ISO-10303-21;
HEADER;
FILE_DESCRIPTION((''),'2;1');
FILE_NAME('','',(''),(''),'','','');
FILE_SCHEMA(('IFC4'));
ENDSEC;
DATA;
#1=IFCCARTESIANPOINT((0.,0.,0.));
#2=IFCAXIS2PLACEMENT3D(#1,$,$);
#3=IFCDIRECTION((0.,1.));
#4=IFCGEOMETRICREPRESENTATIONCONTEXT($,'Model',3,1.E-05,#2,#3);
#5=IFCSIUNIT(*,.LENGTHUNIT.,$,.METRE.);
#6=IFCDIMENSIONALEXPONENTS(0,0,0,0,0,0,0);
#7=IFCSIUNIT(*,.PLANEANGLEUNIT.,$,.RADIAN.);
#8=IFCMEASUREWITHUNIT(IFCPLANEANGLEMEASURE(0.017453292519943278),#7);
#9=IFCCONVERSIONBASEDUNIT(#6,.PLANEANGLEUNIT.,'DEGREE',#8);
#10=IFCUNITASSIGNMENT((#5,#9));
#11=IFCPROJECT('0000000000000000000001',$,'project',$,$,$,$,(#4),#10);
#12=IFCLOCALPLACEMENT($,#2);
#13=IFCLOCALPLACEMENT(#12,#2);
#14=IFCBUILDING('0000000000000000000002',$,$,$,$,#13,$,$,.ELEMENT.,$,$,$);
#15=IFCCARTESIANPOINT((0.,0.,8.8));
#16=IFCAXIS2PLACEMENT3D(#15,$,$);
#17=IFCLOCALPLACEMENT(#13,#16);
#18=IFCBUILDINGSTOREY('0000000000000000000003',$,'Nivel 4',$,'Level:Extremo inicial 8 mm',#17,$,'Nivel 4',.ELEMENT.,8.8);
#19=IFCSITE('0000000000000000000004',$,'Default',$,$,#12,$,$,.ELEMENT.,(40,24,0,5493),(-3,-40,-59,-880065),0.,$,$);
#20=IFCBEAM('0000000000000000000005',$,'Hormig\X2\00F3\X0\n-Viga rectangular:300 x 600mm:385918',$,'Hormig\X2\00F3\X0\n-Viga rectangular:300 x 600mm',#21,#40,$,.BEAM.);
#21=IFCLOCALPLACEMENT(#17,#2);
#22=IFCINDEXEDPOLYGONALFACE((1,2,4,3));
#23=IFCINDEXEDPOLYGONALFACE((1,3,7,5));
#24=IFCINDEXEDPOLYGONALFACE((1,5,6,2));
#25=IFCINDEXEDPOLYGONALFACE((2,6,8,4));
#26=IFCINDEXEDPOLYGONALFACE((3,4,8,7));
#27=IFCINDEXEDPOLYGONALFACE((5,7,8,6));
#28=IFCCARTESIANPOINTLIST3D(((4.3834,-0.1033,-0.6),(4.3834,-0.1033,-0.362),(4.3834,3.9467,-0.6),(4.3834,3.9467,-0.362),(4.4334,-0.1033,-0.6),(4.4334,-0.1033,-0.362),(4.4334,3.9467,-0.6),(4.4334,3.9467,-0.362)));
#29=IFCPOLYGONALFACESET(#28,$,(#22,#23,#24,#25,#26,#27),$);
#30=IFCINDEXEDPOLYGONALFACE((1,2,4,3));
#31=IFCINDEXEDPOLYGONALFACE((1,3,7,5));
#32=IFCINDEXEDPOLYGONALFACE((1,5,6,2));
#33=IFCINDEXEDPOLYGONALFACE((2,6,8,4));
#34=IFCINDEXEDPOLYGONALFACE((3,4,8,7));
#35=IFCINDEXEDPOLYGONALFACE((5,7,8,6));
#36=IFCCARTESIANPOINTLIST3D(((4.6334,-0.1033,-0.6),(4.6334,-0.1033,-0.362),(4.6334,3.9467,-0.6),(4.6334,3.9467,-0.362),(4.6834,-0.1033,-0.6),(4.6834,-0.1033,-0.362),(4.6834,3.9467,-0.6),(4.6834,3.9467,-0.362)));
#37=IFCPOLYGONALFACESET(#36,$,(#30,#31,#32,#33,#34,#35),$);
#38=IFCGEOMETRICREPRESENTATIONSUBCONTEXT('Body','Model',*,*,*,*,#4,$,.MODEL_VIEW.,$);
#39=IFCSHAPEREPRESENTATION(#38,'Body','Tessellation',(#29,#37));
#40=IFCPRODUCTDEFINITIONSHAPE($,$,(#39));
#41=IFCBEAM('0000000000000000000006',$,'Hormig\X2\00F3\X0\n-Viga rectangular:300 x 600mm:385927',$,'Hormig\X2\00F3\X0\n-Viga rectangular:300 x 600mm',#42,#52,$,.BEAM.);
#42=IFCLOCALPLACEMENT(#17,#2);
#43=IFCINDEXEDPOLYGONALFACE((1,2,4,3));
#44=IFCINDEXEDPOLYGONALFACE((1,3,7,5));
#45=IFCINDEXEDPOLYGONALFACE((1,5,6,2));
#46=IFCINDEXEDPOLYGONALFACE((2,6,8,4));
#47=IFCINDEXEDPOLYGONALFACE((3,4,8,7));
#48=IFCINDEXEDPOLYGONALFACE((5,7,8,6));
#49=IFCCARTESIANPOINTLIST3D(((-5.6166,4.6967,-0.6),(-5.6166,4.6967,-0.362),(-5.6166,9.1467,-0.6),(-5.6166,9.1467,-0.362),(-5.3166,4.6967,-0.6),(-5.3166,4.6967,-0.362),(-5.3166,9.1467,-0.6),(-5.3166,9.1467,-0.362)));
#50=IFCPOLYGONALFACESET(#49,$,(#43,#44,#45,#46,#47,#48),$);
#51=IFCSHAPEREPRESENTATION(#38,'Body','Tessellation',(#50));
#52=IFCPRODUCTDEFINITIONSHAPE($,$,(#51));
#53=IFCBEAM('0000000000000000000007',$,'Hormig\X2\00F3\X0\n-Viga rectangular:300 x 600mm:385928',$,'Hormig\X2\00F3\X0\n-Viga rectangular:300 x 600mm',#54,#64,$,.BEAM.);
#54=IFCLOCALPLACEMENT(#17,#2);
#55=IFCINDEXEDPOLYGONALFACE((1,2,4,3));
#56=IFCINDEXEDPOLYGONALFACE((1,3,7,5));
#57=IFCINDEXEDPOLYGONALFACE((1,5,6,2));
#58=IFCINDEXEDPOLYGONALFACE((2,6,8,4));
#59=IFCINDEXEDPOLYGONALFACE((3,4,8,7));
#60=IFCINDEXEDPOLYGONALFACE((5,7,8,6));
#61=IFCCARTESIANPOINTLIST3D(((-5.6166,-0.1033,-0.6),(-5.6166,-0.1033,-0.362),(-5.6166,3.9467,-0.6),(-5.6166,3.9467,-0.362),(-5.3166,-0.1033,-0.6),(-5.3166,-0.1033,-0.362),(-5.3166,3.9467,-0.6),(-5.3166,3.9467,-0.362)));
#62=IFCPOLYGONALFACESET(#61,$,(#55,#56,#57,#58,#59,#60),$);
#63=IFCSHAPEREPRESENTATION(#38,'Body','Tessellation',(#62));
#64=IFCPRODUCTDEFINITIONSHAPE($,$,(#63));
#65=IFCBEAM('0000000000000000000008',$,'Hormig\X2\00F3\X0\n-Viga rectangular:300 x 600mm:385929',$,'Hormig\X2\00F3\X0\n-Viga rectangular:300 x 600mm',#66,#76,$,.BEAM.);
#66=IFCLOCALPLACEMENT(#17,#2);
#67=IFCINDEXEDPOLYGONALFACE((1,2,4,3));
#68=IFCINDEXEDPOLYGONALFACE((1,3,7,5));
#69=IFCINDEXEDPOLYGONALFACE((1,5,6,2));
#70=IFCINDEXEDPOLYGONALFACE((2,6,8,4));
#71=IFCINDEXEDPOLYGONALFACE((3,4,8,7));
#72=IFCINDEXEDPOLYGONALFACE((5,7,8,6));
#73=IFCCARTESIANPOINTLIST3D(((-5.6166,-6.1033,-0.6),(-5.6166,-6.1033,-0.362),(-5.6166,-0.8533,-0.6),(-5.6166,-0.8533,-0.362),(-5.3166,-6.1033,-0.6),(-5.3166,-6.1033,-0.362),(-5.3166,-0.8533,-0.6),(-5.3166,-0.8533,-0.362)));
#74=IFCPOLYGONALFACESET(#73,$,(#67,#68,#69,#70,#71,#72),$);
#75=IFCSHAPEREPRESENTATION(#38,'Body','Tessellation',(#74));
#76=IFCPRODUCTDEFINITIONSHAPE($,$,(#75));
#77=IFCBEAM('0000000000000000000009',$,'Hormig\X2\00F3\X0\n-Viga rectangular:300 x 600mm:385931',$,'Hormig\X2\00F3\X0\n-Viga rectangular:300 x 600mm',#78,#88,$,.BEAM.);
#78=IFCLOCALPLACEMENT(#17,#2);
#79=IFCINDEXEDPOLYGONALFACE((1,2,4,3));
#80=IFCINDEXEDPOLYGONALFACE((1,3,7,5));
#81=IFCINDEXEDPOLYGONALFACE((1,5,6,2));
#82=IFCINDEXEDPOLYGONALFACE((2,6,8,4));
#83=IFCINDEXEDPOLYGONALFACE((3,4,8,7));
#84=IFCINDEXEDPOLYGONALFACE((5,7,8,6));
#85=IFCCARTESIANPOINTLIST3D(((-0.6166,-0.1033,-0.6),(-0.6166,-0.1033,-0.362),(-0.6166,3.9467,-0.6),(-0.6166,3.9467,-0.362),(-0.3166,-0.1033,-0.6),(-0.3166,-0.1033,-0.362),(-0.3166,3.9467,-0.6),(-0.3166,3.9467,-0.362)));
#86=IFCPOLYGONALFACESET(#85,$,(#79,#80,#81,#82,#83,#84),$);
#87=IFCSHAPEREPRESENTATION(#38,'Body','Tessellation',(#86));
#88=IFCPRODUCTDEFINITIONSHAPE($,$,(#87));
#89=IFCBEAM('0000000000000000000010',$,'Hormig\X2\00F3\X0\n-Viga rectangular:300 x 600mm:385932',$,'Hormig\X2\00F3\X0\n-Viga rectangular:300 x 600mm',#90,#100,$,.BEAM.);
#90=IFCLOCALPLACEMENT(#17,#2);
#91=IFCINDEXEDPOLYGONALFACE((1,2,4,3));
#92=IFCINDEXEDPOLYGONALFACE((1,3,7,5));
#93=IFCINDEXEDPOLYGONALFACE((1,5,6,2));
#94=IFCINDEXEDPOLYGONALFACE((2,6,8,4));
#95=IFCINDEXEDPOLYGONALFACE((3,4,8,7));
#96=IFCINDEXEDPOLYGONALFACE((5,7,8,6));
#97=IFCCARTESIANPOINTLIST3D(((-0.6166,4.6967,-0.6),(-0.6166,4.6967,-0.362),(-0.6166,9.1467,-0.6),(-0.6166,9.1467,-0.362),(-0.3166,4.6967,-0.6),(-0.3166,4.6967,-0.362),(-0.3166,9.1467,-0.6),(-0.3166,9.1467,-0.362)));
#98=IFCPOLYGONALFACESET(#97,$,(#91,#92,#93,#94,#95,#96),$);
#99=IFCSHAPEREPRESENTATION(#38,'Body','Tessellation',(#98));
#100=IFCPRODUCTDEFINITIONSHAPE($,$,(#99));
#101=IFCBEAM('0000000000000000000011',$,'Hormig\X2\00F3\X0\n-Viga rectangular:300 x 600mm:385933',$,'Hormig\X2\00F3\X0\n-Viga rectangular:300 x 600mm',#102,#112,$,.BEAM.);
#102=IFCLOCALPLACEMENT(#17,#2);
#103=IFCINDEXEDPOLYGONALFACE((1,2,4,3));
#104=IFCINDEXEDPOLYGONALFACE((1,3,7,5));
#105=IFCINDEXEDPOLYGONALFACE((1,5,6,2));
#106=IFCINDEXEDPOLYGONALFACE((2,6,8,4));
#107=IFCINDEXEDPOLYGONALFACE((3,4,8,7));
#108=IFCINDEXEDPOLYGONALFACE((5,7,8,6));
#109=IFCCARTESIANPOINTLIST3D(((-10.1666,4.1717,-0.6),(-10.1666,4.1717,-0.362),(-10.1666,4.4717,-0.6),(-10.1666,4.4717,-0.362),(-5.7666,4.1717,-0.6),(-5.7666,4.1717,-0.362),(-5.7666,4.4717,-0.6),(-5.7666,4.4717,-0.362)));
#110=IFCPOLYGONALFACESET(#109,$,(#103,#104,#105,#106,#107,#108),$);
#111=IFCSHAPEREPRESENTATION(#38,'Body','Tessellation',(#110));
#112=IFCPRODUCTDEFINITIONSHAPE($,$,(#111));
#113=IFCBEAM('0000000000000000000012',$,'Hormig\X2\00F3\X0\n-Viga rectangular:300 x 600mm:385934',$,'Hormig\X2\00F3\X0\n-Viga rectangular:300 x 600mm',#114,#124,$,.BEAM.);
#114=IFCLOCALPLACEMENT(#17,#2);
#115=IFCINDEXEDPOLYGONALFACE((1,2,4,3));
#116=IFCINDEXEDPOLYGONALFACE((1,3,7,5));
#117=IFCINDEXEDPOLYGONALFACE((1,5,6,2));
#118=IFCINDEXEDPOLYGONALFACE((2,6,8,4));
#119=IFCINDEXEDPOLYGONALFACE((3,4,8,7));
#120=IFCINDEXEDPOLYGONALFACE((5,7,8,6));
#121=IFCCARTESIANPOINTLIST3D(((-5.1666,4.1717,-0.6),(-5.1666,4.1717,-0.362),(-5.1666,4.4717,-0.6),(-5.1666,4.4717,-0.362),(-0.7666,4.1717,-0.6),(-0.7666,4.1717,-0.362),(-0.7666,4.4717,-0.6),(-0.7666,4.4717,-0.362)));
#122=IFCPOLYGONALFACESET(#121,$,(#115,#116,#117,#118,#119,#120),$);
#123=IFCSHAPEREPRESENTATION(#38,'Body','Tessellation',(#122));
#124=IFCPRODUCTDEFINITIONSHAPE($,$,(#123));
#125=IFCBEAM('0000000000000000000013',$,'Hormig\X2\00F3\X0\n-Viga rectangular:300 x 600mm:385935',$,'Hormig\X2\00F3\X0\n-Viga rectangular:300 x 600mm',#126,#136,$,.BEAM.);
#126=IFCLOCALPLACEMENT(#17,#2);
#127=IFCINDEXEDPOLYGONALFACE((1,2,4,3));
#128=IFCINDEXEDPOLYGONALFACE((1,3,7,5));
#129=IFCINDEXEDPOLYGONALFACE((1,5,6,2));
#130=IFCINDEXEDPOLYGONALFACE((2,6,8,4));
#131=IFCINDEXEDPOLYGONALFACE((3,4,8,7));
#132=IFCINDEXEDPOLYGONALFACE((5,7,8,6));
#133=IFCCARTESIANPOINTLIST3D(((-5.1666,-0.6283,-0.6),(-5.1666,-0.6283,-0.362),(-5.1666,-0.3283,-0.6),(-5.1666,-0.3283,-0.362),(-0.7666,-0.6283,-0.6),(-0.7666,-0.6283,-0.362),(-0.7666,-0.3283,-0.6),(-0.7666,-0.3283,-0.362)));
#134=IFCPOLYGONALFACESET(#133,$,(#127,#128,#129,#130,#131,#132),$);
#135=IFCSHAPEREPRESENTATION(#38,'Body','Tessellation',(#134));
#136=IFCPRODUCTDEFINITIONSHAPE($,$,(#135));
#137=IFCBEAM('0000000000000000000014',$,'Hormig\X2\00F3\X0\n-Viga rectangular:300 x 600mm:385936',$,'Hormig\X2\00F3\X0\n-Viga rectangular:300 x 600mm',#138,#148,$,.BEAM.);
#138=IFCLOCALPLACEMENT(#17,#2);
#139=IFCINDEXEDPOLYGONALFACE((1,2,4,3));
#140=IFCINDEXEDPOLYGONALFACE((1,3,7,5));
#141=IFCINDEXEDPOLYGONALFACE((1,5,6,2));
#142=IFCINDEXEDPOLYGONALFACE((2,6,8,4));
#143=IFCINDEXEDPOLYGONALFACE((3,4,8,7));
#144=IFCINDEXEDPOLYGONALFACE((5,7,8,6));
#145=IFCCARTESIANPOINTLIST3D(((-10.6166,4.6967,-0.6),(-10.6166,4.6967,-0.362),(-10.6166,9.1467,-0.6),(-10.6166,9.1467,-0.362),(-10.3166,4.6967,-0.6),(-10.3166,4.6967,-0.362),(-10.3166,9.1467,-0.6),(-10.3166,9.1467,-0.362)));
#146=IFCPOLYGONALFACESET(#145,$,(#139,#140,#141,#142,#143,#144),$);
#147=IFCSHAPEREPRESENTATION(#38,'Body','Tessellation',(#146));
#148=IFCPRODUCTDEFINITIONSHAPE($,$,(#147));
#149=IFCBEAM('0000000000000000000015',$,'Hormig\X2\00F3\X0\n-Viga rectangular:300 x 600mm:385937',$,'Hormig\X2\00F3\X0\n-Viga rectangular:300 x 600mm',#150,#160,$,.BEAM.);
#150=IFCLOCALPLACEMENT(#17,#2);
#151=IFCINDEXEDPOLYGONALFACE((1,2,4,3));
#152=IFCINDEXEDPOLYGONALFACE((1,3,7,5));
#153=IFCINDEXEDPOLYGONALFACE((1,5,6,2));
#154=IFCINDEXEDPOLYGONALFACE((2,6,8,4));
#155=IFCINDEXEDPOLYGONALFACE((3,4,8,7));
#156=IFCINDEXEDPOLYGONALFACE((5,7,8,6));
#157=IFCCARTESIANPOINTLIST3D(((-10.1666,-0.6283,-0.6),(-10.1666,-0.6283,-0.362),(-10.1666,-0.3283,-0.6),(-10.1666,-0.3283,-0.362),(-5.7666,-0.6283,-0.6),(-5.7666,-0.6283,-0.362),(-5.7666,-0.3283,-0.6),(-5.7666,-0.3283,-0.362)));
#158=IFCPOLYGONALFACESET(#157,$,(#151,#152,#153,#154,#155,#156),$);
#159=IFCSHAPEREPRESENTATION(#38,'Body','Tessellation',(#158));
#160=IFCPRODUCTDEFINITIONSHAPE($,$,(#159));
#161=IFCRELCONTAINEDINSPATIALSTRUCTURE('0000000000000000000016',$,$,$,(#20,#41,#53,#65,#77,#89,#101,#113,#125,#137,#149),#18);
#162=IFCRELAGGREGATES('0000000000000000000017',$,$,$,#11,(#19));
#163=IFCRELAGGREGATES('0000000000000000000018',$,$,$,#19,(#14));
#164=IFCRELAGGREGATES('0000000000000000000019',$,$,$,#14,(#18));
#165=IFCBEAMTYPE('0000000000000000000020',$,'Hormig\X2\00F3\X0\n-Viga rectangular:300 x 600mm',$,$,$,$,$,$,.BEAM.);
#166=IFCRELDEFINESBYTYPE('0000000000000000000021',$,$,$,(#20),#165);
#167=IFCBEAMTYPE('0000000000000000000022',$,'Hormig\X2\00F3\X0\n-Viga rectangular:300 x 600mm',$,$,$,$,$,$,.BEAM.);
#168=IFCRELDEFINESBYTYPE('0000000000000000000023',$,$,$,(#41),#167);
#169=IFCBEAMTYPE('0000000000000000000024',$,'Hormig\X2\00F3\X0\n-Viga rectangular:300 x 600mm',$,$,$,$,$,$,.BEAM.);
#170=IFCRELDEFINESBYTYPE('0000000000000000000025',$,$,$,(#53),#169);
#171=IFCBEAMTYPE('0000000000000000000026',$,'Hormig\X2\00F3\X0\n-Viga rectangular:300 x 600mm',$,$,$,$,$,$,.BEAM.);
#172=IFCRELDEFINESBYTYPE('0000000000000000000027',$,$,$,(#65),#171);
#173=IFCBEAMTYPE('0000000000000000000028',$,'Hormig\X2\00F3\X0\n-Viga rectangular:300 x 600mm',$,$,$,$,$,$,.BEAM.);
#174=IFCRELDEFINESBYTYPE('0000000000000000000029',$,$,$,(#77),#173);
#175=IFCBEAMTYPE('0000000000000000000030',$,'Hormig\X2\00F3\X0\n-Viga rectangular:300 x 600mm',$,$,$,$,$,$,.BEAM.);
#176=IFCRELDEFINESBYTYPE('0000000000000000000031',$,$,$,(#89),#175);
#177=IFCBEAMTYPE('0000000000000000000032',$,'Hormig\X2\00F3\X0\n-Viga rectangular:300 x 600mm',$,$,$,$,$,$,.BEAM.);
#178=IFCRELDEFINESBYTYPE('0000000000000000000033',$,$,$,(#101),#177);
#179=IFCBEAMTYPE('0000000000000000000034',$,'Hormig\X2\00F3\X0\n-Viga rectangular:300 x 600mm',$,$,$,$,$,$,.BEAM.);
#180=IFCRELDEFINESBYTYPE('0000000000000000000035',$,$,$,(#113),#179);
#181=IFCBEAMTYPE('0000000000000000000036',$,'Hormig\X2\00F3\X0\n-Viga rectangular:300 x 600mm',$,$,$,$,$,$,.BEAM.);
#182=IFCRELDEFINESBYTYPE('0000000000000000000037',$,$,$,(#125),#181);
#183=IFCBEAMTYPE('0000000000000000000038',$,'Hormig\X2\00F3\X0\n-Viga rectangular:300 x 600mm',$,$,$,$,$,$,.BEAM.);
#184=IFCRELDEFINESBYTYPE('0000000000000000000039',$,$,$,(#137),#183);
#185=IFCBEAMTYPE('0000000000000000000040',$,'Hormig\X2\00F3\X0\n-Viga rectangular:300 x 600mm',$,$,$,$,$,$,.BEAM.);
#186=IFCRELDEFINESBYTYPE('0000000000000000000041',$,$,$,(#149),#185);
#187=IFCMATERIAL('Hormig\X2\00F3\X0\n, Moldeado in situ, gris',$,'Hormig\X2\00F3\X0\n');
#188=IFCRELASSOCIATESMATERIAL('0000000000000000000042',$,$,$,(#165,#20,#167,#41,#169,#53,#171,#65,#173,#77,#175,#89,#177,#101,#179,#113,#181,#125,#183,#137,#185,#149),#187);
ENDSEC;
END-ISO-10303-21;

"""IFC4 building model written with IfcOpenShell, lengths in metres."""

from ifc_helpers import new_model, entity, si_unit, converted_unit, direction, frame, origin, place, context, subcontext, project, spatial, indexed_curve, outline, extrude, source, transform, mapped, material, type_object, type_shapes, element, save


model = new_model("IFC4")

# Units and contexts
model_context = context("Model", 3, precision=1e-05, world=origin(), true_north=direction((0.0, 1.0)))
body_context = subcontext(model_context, "Body", "Model", "MODEL_VIEW")
ifc_project = project(units=[si_unit("LENGTHUNIT", "METRE"), converted_unit("PLANEANGLEUNIT", "DEGREE", entity("IfcPlaneAngleMeasure", 0.017453292519943278), si_unit("PLANEANGLEUNIT", "RADIAN"), dimensions=[0, 0, 0, 0, 0, 0, 0])], contexts=[model_context])

# Site, building, storey
site_placement = place(None, origin())
site = spatial("IfcSite", under=ifc_project, at=site_placement, Name="Default", CompositionType="ELEMENT", RefLatitude=(40, 24, 0, 5493), RefLongitude=(-3, -40, -59, -880065), RefElevation=0.0)
building_placement = place(site_placement, origin())
building = spatial("IfcBuilding", under=site, at=building_placement, CompositionType="ELEMENT")
storey_placement = place(building_placement, frame((0.0, 0.0, 8.8)))
storey = spatial("IfcBuildingStorey", under=building, at=storey_placement, Name="Nivel 4", ObjectType="Level:Extremo inicial 8 mm", LongName="Nivel 4", CompositionType="ELEMENT", Elevation=8.8)

# Shared definitions
ifc_material_1 = material(Name="Hormigón, Moldeado in situ, gris", Category="Hormigón")

# Beams
beam_type_1 = type_object("IfcBeamType", Name="Hormigón-Viga rectangular:300 x 600mm", PredefinedType="BEAM", material=ifc_material_1)
shared_shape_1 = source(origin(), body_context, "Body", "SweptSolid", [
    extrude(outline(indexed_curve([(-0.025, -0.119), (0.025, -0.119), (0.025, 0.119), (-0.025, 0.119), (-0.025, -0.119)], self_intersect=False)), frame((4.4084, 3.9467, 8.319), z_axis=(0.0, -1.0, 0.0), x_axis=(-1.0, 0.0, 0.0)), (0.0, 0.0, 1.0), 4.05),
    extrude(outline(indexed_curve([(-0.025, -0.119), (0.025, -0.119), (0.025, 0.119), (-0.025, 0.119), (-0.025, -0.119)], self_intersect=False)), frame((4.6584, 3.9467, 8.319), z_axis=(0.0, -1.0, 0.0), x_axis=(-1.0, 0.0, 0.0)), (0.0, 0.0, 1.0), 4.05),
])
type_shapes(beam_type_1, [shared_shape_1])
beam_1_placement = place(storey_placement, frame((0.0, 0.0, -8.8)))
element("IfcBeam", 1, at=beam_1_placement, inside=storey, type_object=beam_type_1, material=ifc_material_1, Name="Hormigón-Viga rectangular:300 x 600mm:385918", ObjectType="Hormigón-Viga rectangular:300 x 600mm", PredefinedType="BEAM", context=body_context, shape_type="MappedRepresentation", body=[
    mapped(shared_shape_1, transform((0.0, 0.0, 0.0), scale=1.0)),
])
beam_type_2 = type_object("IfcBeamType", Name="Hormigón-Viga rectangular:300 x 600mm", PredefinedType="BEAM", material=ifc_material_1)
shared_shape_2 = source(origin(), body_context, "Body", "SweptSolid", [
    extrude(outline(indexed_curve([(-0.15, -0.119), (0.15, -0.119), (0.15, 0.119), (-0.15, 0.119), (-0.15, -0.119)], self_intersect=False)), frame((-5.4666, 9.1467, 8.319), z_axis=(0.0, -1.0, 0.0), x_axis=(-1.0, 0.0, 0.0)), (0.0, 0.0, 1.0), 4.45),
])
type_shapes(beam_type_2, [shared_shape_2])
beam_2_placement = place(storey_placement, frame((0.0, 0.0, -8.8)))
element("IfcBeam", 2, at=beam_2_placement, inside=storey, type_object=beam_type_2, material=ifc_material_1, Name="Hormigón-Viga rectangular:300 x 600mm:385927", ObjectType="Hormigón-Viga rectangular:300 x 600mm", PredefinedType="BEAM", context=body_context, shape_type="MappedRepresentation", body=[
    mapped(shared_shape_2, transform((0.0, 0.0, 0.0), scale=1.0)),
])
beam_type_3 = type_object("IfcBeamType", Name="Hormigón-Viga rectangular:300 x 600mm", PredefinedType="BEAM", material=ifc_material_1)
shared_shape_3 = source(origin(), body_context, "Body", "SweptSolid", [
    extrude(outline(indexed_curve([(-0.15, -0.119), (0.15, -0.119), (0.15, 0.119), (-0.15, 0.119), (-0.15, -0.119)], self_intersect=False)), frame((-5.4666, 3.9467, 8.319), z_axis=(0.0, -1.0, 0.0), x_axis=(-1.0, 0.0, 0.0)), (0.0, 0.0, 1.0), 4.05),
])
type_shapes(beam_type_3, [shared_shape_3])
beam_3_placement = place(storey_placement, frame((0.0, 0.0, -8.8)))
element("IfcBeam", 3, at=beam_3_placement, inside=storey, type_object=beam_type_3, material=ifc_material_1, Name="Hormigón-Viga rectangular:300 x 600mm:385928", ObjectType="Hormigón-Viga rectangular:300 x 600mm", PredefinedType="BEAM", context=body_context, shape_type="MappedRepresentation", body=[
    mapped(shared_shape_3, transform((0.0, 0.0, 0.0), scale=1.0)),
])
beam_type_4 = type_object("IfcBeamType", Name="Hormigón-Viga rectangular:300 x 600mm", PredefinedType="BEAM", material=ifc_material_1)
shared_shape_4 = source(origin(), body_context, "Body", "SweptSolid", [
    extrude(outline(indexed_curve([(-0.15, -0.119), (0.15, -0.119), (0.15, 0.119), (-0.15, 0.119), (-0.15, -0.119)], self_intersect=False)), frame((-5.4666, -6.1033, 8.319), z_axis=(0.0, 1.0, 0.0), x_axis=(-1.0, 0.0, 0.0)), (0.0, 0.0, 1.0), 5.25),
])
type_shapes(beam_type_4, [shared_shape_4])
beam_4_placement = place(storey_placement, frame((0.0, 0.0, -8.8)))
element("IfcBeam", 4, at=beam_4_placement, inside=storey, type_object=beam_type_4, material=ifc_material_1, Name="Hormigón-Viga rectangular:300 x 600mm:385929", ObjectType="Hormigón-Viga rectangular:300 x 600mm", PredefinedType="BEAM", context=body_context, shape_type="MappedRepresentation", body=[
    mapped(shared_shape_4, transform((0.0, 0.0, 0.0), scale=1.0)),
])
beam_type_5 = type_object("IfcBeamType", Name="Hormigón-Viga rectangular:300 x 600mm", PredefinedType="BEAM", material=ifc_material_1)
shared_shape_5 = source(origin(), body_context, "Body", "SweptSolid", [
    extrude(outline(indexed_curve([(-0.15, -0.119), (0.15, -0.119), (0.15, 0.119), (-0.15, 0.119), (-0.15, -0.119)], self_intersect=False)), frame((-0.4666, -0.1033, 8.319), z_axis=(0.0, 1.0, 0.0), x_axis=(-1.0, 0.0, 0.0)), (0.0, 0.0, 1.0), 4.05),
])
type_shapes(beam_type_5, [shared_shape_5])
beam_5_placement = place(storey_placement, frame((0.0, 0.0, -8.8)))
element("IfcBeam", 5, at=beam_5_placement, inside=storey, type_object=beam_type_5, material=ifc_material_1, Name="Hormigón-Viga rectangular:300 x 600mm:385931", ObjectType="Hormigón-Viga rectangular:300 x 600mm", PredefinedType="BEAM", context=body_context, shape_type="MappedRepresentation", body=[
    mapped(shared_shape_5, transform((0.0, 0.0, 0.0), scale=1.0)),
])
beam_type_6 = type_object("IfcBeamType", Name="Hormigón-Viga rectangular:300 x 600mm", PredefinedType="BEAM", material=ifc_material_1)
shared_shape_6 = source(origin(), body_context, "Body", "SweptSolid", [
    extrude(outline(indexed_curve([(-0.15, -0.119), (0.15, -0.119), (0.15, 0.119), (-0.15, 0.119), (-0.15, -0.119)], self_intersect=False)), frame((-0.4666, 9.1467, 8.319), z_axis=(0.0, -1.0, 0.0), x_axis=(-1.0, 0.0, 0.0)), (0.0, 0.0, 1.0), 4.45),
])
type_shapes(beam_type_6, [shared_shape_6])
beam_6_placement = place(storey_placement, frame((0.0, 0.0, -8.8)))
element("IfcBeam", 6, at=beam_6_placement, inside=storey, type_object=beam_type_6, material=ifc_material_1, Name="Hormigón-Viga rectangular:300 x 600mm:385932", ObjectType="Hormigón-Viga rectangular:300 x 600mm", PredefinedType="BEAM", context=body_context, shape_type="MappedRepresentation", body=[
    mapped(shared_shape_6, transform((0.0, 0.0, 0.0), scale=1.0)),
])
beam_type_7 = type_object("IfcBeamType", Name="Hormigón-Viga rectangular:300 x 600mm", PredefinedType="BEAM", material=ifc_material_1)
shared_shape_7 = source(origin(), body_context, "Body", "SweptSolid", [
    extrude(outline(indexed_curve([(-0.119, -0.15), (0.119, -0.15), (0.119, 0.15), (-0.119, 0.15), (-0.119, -0.15)], self_intersect=False)), frame((-10.1666, 4.3217, 8.319), z_axis=(1.0, 0.0, 0.0), x_axis=(0.0, 0.0, -1.0)), (0.0, 0.0, 1.0), 4.4),
])
type_shapes(beam_type_7, [shared_shape_7])
beam_7_placement = place(storey_placement, frame((0.0, 0.0, -8.8)))
element("IfcBeam", 7, at=beam_7_placement, inside=storey, type_object=beam_type_7, material=ifc_material_1, Name="Hormigón-Viga rectangular:300 x 600mm:385933", ObjectType="Hormigón-Viga rectangular:300 x 600mm", PredefinedType="BEAM", context=body_context, shape_type="MappedRepresentation", body=[
    mapped(shared_shape_7, transform((0.0, 0.0, 0.0), scale=1.0)),
])
beam_type_8 = type_object("IfcBeamType", Name="Hormigón-Viga rectangular:300 x 600mm", PredefinedType="BEAM", material=ifc_material_1)
shared_shape_8 = source(origin(), body_context, "Body", "SweptSolid", [
    extrude(outline(indexed_curve([(-0.119, -0.15), (0.119, -0.15), (0.119, 0.15), (-0.119, 0.15), (-0.119, -0.15)], self_intersect=False)), frame((-5.1666, 4.3217, 8.319), z_axis=(1.0, 0.0, 0.0), x_axis=(0.0, 0.0, -1.0)), (0.0, 0.0, 1.0), 4.4),
])
type_shapes(beam_type_8, [shared_shape_8])
beam_8_placement = place(storey_placement, frame((0.0, 0.0, -8.8)))
element("IfcBeam", 8, at=beam_8_placement, inside=storey, type_object=beam_type_8, material=ifc_material_1, Name="Hormigón-Viga rectangular:300 x 600mm:385934", ObjectType="Hormigón-Viga rectangular:300 x 600mm", PredefinedType="BEAM", context=body_context, shape_type="MappedRepresentation", body=[
    mapped(shared_shape_8, transform((0.0, 0.0, 0.0), scale=1.0)),
])
beam_type_9 = type_object("IfcBeamType", Name="Hormigón-Viga rectangular:300 x 600mm", PredefinedType="BEAM", material=ifc_material_1)
shared_shape_9 = source(origin(), body_context, "Body", "SweptSolid", [
    extrude(outline(indexed_curve([(-0.119, -0.15), (0.119, -0.15), (0.119, 0.15), (-0.119, 0.15), (-0.119, -0.15)], self_intersect=False)), frame((-0.7666, -0.4783, 8.319), z_axis=(-1.0, 0.0, 0.0), x_axis=(0.0, 0.0, -1.0)), (0.0, 0.0, 1.0), 4.4),
])
type_shapes(beam_type_9, [shared_shape_9])
beam_9_placement = place(storey_placement, frame((0.0, 0.0, -8.8)))
element("IfcBeam", 9, at=beam_9_placement, inside=storey, type_object=beam_type_9, material=ifc_material_1, Name="Hormigón-Viga rectangular:300 x 600mm:385935", ObjectType="Hormigón-Viga rectangular:300 x 600mm", PredefinedType="BEAM", context=body_context, shape_type="MappedRepresentation", body=[
    mapped(shared_shape_9, transform((0.0, 0.0, 0.0), scale=1.0)),
])
beam_type_10 = type_object("IfcBeamType", Name="Hormigón-Viga rectangular:300 x 600mm", PredefinedType="BEAM", material=ifc_material_1)
shared_shape_10 = source(origin(), body_context, "Body", "SweptSolid", [
    extrude(outline(indexed_curve([(-0.15, -0.119), (0.15, -0.119), (0.15, 0.119), (-0.15, 0.119), (-0.15, -0.119)], self_intersect=False)), frame((-10.4666, 4.6967, 8.319), z_axis=(0.0, 1.0, 0.0), x_axis=(-1.0, 0.0, 0.0)), (0.0, 0.0, 1.0), 4.45),
])
type_shapes(beam_type_10, [shared_shape_10])
beam_10_placement = place(storey_placement, frame((0.0, 0.0, -8.8)))
element("IfcBeam", 10, at=beam_10_placement, inside=storey, type_object=beam_type_10, material=ifc_material_1, Name="Hormigón-Viga rectangular:300 x 600mm:385936", ObjectType="Hormigón-Viga rectangular:300 x 600mm", PredefinedType="BEAM", context=body_context, shape_type="MappedRepresentation", body=[
    mapped(shared_shape_10, transform((0.0, 0.0, 0.0), scale=1.0)),
])
beam_type_11 = type_object("IfcBeamType", Name="Hormigón-Viga rectangular:300 x 600mm", PredefinedType="BEAM", material=ifc_material_1)
shared_shape_11 = source(origin(), body_context, "Body", "SweptSolid", [
    extrude(outline(indexed_curve([(-0.119, -0.15), (0.119, -0.15), (0.119, 0.15), (-0.119, 0.15), (-0.119, -0.15)], self_intersect=False)), frame((-10.1666, -0.4783, 8.319), z_axis=(1.0, 0.0, 0.0), x_axis=(0.0, 0.0, -1.0)), (0.0, 0.0, 1.0), 4.4),
])
type_shapes(beam_type_11, [shared_shape_11])
beam_11_placement = place(storey_placement, frame((0.0, 0.0, -8.8)))
element("IfcBeam", 11, at=beam_11_placement, inside=storey, type_object=beam_type_11, material=ifc_material_1, Name="Hormigón-Viga rectangular:300 x 600mm:385937", ObjectType="Hormigón-Viga rectangular:300 x 600mm", PredefinedType="BEAM", context=body_context, shape_type="MappedRepresentation", body=[
    mapped(shared_shape_11, transform((0.0, 0.0, 0.0), scale=1.0)),
])

save(model, "model.ifc")
